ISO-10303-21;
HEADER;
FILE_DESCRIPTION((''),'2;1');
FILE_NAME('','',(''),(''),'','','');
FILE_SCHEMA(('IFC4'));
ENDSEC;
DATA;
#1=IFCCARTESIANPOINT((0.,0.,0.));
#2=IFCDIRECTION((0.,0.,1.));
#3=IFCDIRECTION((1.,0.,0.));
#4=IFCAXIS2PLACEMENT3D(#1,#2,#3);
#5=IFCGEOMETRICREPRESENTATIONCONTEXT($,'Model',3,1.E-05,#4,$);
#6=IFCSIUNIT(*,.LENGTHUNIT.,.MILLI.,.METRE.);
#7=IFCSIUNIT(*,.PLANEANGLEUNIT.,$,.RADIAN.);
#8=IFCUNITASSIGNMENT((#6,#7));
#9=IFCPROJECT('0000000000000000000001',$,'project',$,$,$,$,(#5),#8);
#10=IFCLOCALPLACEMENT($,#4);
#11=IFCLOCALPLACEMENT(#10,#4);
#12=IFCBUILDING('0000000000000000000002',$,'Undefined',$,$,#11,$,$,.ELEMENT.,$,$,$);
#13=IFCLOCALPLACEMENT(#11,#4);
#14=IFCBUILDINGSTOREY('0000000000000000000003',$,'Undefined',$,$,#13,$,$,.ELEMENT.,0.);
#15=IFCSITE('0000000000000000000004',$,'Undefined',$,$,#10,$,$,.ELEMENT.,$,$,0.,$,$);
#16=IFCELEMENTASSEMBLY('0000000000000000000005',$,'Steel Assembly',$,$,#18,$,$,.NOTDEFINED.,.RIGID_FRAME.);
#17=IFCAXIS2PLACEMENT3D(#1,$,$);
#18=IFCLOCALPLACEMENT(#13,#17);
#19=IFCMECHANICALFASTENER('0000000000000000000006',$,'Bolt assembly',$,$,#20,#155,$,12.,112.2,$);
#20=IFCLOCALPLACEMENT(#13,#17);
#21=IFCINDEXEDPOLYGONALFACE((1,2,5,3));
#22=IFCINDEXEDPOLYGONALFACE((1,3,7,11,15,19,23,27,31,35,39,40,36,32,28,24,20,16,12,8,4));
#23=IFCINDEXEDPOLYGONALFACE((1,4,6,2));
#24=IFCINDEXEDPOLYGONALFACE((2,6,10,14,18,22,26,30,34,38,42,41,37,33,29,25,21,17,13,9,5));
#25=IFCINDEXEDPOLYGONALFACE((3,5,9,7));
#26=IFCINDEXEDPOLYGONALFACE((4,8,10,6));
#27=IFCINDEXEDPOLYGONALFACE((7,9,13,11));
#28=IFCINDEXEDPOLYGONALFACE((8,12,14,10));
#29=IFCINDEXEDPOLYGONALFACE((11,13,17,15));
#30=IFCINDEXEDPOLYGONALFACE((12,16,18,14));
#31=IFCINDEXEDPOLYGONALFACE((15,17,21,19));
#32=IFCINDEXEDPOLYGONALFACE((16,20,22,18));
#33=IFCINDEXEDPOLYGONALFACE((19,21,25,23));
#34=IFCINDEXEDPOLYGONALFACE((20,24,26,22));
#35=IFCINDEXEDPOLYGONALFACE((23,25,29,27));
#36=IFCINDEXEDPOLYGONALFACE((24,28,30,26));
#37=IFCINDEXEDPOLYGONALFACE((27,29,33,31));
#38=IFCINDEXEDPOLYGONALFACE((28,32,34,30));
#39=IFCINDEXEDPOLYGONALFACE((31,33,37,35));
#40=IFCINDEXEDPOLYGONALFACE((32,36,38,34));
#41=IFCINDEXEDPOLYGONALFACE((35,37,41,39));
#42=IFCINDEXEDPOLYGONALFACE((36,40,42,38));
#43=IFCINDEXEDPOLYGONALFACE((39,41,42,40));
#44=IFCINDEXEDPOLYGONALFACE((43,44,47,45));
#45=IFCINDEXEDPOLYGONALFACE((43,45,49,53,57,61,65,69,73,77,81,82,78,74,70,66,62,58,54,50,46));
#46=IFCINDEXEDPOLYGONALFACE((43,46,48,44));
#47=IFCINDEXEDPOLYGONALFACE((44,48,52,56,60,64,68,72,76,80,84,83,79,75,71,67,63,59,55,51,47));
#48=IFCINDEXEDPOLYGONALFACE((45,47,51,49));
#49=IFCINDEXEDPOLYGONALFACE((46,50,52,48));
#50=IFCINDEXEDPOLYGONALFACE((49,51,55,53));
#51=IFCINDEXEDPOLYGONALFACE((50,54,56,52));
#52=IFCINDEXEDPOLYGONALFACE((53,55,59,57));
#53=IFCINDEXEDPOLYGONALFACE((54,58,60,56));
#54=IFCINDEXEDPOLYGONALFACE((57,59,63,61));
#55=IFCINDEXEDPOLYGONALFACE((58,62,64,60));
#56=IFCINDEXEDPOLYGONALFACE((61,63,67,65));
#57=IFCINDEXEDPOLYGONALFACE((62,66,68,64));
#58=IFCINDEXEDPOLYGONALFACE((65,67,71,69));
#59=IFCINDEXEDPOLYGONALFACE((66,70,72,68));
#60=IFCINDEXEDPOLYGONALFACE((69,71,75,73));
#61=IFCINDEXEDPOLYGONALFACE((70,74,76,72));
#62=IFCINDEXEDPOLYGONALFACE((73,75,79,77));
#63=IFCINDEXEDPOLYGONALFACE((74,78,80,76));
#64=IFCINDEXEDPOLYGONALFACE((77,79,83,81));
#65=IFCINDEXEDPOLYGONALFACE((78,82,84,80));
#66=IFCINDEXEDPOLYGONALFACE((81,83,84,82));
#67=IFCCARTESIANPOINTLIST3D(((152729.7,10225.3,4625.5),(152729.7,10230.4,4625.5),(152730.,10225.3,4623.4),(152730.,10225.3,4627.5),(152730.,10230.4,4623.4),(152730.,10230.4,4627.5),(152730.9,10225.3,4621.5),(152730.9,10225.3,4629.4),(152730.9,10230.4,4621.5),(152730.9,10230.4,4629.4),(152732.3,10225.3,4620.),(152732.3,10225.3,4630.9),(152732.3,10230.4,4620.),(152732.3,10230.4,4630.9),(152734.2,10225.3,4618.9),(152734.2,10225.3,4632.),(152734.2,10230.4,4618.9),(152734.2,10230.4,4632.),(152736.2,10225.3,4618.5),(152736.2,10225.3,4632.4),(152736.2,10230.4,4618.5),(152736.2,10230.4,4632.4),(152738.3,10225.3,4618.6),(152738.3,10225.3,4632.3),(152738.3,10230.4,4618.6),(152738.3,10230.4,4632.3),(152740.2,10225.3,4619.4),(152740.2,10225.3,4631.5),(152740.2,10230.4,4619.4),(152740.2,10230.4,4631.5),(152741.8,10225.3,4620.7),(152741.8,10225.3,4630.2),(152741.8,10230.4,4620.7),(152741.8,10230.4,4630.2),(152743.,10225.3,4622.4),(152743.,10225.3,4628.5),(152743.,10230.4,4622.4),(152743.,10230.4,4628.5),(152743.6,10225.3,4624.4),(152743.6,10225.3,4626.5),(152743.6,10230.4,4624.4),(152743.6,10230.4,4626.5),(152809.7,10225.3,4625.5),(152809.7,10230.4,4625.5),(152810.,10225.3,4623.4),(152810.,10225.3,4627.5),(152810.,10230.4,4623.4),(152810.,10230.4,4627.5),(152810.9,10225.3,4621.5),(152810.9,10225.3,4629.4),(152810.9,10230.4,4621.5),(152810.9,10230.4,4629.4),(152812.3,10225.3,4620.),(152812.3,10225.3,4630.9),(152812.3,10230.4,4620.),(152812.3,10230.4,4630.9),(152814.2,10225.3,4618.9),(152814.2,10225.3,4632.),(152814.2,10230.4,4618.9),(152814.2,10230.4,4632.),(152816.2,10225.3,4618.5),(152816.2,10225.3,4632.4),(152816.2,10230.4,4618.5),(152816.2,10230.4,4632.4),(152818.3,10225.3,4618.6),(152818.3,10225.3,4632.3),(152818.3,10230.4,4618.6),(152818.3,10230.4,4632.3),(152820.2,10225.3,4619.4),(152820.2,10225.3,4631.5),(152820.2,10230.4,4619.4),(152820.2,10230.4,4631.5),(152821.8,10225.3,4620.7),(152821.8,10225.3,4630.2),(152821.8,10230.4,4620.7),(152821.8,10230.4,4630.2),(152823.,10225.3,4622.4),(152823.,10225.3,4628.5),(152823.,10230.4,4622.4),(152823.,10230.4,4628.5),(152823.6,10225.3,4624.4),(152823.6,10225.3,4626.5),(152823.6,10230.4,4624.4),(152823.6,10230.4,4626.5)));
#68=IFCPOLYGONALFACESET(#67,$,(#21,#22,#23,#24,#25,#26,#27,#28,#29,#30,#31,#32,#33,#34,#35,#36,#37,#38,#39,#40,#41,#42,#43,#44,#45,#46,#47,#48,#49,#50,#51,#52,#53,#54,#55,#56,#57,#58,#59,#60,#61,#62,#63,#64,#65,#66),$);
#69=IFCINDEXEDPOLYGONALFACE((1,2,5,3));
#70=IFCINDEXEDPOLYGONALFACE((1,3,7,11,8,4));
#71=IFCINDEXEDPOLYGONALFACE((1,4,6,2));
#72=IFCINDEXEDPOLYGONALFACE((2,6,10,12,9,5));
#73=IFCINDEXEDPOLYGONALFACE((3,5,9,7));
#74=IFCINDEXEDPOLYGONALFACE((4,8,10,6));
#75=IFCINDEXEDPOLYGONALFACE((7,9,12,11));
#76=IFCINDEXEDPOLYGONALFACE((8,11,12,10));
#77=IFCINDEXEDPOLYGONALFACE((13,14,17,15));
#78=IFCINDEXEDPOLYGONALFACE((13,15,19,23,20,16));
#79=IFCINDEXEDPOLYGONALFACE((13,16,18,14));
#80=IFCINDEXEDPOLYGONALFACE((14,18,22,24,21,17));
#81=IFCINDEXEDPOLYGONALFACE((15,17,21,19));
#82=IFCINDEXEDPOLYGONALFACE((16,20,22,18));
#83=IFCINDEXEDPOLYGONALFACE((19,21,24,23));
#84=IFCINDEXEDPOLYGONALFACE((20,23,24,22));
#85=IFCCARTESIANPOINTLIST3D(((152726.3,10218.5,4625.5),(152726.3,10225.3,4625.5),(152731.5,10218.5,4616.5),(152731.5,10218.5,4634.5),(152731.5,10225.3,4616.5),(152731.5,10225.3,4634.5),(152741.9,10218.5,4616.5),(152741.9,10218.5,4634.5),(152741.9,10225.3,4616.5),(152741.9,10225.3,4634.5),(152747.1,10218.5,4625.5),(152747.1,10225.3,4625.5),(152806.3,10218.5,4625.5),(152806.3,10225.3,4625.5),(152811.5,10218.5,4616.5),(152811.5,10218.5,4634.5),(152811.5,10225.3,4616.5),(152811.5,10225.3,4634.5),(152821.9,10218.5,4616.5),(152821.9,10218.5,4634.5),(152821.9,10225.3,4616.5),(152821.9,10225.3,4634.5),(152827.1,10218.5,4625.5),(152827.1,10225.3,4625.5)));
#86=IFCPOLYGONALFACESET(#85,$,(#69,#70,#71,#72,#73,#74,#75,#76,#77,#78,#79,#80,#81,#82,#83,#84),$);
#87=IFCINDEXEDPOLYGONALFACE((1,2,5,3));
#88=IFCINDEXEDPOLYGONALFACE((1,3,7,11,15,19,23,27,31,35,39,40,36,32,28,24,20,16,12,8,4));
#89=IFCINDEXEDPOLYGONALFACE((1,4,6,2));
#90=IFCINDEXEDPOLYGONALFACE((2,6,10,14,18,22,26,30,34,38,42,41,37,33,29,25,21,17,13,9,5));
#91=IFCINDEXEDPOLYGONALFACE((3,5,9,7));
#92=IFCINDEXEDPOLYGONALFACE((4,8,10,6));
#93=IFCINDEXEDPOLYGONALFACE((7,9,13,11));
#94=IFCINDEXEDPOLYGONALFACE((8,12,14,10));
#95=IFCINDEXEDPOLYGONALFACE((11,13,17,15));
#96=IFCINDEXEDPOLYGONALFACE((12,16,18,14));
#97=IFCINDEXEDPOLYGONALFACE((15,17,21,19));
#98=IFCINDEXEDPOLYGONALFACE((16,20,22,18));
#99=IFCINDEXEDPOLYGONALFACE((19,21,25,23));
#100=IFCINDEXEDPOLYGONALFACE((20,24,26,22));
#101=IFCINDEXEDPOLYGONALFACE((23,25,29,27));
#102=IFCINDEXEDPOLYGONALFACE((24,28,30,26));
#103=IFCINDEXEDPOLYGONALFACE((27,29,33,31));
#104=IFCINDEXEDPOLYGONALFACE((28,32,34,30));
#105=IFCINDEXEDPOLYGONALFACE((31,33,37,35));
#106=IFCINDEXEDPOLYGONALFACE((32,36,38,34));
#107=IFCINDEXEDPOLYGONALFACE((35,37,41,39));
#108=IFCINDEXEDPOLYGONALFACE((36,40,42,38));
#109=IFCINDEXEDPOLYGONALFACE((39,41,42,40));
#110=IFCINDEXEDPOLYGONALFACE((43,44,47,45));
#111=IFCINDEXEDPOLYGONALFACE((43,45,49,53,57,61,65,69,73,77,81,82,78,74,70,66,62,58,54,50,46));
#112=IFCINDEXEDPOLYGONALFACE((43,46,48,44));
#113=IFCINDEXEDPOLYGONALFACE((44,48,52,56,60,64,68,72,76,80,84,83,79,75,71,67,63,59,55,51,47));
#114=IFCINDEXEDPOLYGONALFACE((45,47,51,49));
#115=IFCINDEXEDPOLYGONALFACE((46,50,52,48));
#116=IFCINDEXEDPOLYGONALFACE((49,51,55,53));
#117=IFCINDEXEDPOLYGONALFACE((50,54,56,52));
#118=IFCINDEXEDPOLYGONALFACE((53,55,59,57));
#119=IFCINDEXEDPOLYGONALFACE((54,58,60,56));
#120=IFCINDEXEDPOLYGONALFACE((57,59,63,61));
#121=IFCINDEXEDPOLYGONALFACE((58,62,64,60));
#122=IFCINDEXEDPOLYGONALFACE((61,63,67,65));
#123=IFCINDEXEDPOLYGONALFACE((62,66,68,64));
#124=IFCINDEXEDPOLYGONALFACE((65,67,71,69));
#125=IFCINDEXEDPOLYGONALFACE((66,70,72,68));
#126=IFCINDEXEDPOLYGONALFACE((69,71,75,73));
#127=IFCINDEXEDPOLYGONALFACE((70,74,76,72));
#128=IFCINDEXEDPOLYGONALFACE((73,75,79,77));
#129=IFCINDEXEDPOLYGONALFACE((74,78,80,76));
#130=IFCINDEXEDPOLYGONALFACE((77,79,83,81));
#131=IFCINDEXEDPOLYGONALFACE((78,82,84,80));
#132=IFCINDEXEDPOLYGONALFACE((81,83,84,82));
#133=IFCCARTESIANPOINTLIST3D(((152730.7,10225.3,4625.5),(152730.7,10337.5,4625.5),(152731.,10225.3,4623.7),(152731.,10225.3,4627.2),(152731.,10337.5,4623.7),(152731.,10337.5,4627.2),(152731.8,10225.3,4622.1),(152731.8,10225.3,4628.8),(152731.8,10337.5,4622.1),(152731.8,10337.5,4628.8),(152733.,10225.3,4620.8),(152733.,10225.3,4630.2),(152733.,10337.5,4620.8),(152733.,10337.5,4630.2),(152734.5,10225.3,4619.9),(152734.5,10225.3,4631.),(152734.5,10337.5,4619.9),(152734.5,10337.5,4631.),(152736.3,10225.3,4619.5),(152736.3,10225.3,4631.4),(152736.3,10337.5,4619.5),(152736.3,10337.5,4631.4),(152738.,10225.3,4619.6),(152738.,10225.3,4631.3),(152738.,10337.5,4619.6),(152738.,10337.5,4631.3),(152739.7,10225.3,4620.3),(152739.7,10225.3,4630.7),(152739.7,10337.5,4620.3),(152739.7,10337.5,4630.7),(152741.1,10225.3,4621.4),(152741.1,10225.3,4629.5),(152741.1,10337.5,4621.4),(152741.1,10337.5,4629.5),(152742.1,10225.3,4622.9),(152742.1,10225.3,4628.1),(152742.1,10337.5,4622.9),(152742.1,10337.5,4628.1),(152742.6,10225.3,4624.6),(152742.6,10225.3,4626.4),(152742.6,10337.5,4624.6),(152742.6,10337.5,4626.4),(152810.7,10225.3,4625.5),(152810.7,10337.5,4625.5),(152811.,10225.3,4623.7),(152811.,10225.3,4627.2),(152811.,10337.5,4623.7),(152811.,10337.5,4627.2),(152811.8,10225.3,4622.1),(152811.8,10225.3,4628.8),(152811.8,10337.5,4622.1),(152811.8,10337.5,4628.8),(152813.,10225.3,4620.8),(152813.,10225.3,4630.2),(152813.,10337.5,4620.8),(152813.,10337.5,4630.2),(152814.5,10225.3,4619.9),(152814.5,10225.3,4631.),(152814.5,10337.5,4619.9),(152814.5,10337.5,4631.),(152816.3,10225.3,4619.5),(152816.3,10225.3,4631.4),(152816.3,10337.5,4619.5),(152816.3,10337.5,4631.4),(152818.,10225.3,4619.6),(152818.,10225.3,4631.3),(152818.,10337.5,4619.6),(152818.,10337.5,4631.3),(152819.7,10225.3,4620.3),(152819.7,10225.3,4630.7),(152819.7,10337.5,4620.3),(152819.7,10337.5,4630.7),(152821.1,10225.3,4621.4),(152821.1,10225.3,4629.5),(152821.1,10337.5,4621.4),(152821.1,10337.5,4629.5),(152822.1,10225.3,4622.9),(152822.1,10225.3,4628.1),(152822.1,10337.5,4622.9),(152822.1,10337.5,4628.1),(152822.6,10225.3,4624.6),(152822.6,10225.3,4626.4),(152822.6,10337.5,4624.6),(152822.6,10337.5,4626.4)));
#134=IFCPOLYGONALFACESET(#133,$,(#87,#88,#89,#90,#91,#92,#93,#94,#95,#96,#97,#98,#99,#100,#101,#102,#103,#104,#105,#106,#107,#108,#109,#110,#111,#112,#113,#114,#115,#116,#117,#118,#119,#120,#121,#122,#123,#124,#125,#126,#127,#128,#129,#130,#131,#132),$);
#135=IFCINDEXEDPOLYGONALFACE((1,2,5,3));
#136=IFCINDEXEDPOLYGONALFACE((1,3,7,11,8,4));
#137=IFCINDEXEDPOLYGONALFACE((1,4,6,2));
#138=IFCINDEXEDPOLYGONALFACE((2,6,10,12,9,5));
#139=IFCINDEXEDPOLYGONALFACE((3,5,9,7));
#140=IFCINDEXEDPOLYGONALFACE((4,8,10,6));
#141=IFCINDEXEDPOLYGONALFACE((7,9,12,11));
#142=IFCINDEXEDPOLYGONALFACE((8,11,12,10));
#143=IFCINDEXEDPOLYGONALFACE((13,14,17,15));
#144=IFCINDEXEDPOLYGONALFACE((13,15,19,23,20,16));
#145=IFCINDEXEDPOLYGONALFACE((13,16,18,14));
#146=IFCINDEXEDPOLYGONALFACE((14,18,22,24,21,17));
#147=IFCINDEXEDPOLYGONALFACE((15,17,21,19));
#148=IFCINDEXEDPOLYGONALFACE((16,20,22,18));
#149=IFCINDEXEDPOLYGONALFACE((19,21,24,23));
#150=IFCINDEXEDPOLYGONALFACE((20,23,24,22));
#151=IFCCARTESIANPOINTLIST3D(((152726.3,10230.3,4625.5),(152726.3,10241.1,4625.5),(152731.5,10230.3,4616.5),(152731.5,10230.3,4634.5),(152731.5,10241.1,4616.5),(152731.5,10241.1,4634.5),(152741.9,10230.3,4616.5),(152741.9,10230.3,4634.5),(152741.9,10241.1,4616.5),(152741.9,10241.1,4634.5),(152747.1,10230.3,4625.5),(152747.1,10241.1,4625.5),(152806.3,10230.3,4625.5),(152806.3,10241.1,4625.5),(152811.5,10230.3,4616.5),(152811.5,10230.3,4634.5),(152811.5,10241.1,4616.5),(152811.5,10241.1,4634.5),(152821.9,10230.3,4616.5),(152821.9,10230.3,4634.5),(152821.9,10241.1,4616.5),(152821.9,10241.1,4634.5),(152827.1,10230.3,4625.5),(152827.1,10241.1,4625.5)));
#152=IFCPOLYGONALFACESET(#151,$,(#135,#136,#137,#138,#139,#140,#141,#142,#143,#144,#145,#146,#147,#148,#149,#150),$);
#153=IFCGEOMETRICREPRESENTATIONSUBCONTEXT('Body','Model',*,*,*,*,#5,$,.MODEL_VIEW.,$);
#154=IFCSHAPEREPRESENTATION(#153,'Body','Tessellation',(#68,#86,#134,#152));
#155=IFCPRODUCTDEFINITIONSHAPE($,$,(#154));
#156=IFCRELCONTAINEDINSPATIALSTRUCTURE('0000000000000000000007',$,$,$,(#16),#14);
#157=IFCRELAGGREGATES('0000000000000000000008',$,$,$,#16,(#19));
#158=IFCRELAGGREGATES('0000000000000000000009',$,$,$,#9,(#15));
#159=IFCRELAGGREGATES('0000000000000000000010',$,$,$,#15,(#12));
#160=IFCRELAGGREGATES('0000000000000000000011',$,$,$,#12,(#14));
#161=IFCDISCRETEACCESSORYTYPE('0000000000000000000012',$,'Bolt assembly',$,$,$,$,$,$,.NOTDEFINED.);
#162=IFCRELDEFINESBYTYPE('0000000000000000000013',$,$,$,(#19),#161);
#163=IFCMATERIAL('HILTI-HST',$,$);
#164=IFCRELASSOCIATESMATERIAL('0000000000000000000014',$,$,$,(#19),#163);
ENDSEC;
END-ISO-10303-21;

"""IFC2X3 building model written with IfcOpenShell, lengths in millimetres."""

from ifc_helpers import new_model, si_unit, frame, origin_with_axes, origin_2d_with_axis, place, context, subcontext, project, spatial, polyline, circle, outline, extrude, source, transform, mapped, material, type_object, element, aggregate, save


model = new_model("IFC2X3")

# Units and contexts
model_context = context("Model", 3, precision=1e-05, world=origin_with_axes())
body_context = subcontext(model_context, "Body", "Model", "MODEL_VIEW")
ifc_project = project(units=[si_unit("LENGTHUNIT", "METRE", prefix="MILLI"), si_unit("PLANEANGLEUNIT", "RADIAN")], contexts=[model_context])

# Site, building, storey
site_placement = place(None, origin_with_axes())
site = spatial("IfcSite", under=ifc_project, at=site_placement, Name="Undefined", CompositionType="ELEMENT", RefElevation=0.0)
building_placement = place(site_placement, origin_with_axes())
building = spatial("IfcBuilding", under=site, at=building_placement, Name="Undefined", CompositionType="ELEMENT")
storey_placement = place(building_placement, origin_with_axes())
storey = spatial("IfcBuildingStorey", under=building, at=storey_placement, Name="Undefined", CompositionType="ELEMENT", Elevation=0.0)

# Element assembly
assembly_1_placement = place(storey_placement, origin_with_axes())
assembly_1 = element("IfcElementAssembly", 1, at=assembly_1_placement, inside=storey, Name="Steel Assembly", AssemblyPlace="NOTDEFINED", PredefinedType="RIGID_FRAME")

# Mechanical fastener
ifc_material_1 = material(Name="HILTI-HST")
discrete_accessory_type_1 = type_object("IfcDiscreteAccessoryType", Name="Bolt assembly")
shared_shape_1 = source(origin_with_axes(), body_context, "Body", "SweptSolid", [
    extrude(circle(Radius=7.0, at=origin_2d_with_axis()), frame((0.0, 0.0, 0.0), z_axis=(0.0, 1.0, 0.0), x_axis=(1.0, 0.0, 0.0)), (0.0, 0.0, 1.0), 5.1),
    extrude(outline(polyline([(10.4, 0.0), (5.2, 9.0), (-5.2, 9.0), (-10.4, 0.0), (-5.2, -9.0), (5.2, -9.0), (10.4, 0.0)])), frame((0.0, -6.8, 0.0), z_axis=(0.0, 1.0, 0.0), x_axis=(1.0, 0.0, 0.0)), (0.0, 0.0, 1.0), 6.8),
    extrude(circle(Radius=6.0, at=origin_2d_with_axis()), frame((0.0, 0.0, 0.0), z_axis=(0.0, 1.0, 0.0), x_axis=(1.0, 0.0, 0.0)), (0.0, 0.0, 1.0), 112.2),
    extrude(outline(polyline([(10.4, 0.0), (5.2, 9.0), (-5.2, 9.0), (-10.4, 0.0), (-5.2, -9.0), (5.2, -9.0), (10.4, 0.0)])), frame((0.0, 5.0, 0.0), z_axis=(0.0, 1.0, 0.0), x_axis=(1.0, 0.0, 0.0)), (0.0, 0.0, 1.0), 10.8),
])
mechanical_fastener_1_placement = place(assembly_1_placement, frame((152816.7, 10225.3, 4625.5), z_axis=(0.0, 0.0, -1.0), x_axis=(-1.0, 0.0, 0.0)))
mechanical_fastener_1 = element("IfcMechanicalFastener", 2, at=mechanical_fastener_1_placement, type_object=discrete_accessory_type_1, material=ifc_material_1, Name="Bolt assembly", NominalDiameter=12.0, NominalLength=112.2, context=body_context, shape_type="MappedRepresentation", body=[
    mapped(shared_shape_1, transform((0.0, 0.0, 0.0))),
    mapped(shared_shape_1, transform((80.0, 0.0, 0.0))),
])
aggregate(assembly_1, [mechanical_fastener_1])

save(model, "model.ifc")
